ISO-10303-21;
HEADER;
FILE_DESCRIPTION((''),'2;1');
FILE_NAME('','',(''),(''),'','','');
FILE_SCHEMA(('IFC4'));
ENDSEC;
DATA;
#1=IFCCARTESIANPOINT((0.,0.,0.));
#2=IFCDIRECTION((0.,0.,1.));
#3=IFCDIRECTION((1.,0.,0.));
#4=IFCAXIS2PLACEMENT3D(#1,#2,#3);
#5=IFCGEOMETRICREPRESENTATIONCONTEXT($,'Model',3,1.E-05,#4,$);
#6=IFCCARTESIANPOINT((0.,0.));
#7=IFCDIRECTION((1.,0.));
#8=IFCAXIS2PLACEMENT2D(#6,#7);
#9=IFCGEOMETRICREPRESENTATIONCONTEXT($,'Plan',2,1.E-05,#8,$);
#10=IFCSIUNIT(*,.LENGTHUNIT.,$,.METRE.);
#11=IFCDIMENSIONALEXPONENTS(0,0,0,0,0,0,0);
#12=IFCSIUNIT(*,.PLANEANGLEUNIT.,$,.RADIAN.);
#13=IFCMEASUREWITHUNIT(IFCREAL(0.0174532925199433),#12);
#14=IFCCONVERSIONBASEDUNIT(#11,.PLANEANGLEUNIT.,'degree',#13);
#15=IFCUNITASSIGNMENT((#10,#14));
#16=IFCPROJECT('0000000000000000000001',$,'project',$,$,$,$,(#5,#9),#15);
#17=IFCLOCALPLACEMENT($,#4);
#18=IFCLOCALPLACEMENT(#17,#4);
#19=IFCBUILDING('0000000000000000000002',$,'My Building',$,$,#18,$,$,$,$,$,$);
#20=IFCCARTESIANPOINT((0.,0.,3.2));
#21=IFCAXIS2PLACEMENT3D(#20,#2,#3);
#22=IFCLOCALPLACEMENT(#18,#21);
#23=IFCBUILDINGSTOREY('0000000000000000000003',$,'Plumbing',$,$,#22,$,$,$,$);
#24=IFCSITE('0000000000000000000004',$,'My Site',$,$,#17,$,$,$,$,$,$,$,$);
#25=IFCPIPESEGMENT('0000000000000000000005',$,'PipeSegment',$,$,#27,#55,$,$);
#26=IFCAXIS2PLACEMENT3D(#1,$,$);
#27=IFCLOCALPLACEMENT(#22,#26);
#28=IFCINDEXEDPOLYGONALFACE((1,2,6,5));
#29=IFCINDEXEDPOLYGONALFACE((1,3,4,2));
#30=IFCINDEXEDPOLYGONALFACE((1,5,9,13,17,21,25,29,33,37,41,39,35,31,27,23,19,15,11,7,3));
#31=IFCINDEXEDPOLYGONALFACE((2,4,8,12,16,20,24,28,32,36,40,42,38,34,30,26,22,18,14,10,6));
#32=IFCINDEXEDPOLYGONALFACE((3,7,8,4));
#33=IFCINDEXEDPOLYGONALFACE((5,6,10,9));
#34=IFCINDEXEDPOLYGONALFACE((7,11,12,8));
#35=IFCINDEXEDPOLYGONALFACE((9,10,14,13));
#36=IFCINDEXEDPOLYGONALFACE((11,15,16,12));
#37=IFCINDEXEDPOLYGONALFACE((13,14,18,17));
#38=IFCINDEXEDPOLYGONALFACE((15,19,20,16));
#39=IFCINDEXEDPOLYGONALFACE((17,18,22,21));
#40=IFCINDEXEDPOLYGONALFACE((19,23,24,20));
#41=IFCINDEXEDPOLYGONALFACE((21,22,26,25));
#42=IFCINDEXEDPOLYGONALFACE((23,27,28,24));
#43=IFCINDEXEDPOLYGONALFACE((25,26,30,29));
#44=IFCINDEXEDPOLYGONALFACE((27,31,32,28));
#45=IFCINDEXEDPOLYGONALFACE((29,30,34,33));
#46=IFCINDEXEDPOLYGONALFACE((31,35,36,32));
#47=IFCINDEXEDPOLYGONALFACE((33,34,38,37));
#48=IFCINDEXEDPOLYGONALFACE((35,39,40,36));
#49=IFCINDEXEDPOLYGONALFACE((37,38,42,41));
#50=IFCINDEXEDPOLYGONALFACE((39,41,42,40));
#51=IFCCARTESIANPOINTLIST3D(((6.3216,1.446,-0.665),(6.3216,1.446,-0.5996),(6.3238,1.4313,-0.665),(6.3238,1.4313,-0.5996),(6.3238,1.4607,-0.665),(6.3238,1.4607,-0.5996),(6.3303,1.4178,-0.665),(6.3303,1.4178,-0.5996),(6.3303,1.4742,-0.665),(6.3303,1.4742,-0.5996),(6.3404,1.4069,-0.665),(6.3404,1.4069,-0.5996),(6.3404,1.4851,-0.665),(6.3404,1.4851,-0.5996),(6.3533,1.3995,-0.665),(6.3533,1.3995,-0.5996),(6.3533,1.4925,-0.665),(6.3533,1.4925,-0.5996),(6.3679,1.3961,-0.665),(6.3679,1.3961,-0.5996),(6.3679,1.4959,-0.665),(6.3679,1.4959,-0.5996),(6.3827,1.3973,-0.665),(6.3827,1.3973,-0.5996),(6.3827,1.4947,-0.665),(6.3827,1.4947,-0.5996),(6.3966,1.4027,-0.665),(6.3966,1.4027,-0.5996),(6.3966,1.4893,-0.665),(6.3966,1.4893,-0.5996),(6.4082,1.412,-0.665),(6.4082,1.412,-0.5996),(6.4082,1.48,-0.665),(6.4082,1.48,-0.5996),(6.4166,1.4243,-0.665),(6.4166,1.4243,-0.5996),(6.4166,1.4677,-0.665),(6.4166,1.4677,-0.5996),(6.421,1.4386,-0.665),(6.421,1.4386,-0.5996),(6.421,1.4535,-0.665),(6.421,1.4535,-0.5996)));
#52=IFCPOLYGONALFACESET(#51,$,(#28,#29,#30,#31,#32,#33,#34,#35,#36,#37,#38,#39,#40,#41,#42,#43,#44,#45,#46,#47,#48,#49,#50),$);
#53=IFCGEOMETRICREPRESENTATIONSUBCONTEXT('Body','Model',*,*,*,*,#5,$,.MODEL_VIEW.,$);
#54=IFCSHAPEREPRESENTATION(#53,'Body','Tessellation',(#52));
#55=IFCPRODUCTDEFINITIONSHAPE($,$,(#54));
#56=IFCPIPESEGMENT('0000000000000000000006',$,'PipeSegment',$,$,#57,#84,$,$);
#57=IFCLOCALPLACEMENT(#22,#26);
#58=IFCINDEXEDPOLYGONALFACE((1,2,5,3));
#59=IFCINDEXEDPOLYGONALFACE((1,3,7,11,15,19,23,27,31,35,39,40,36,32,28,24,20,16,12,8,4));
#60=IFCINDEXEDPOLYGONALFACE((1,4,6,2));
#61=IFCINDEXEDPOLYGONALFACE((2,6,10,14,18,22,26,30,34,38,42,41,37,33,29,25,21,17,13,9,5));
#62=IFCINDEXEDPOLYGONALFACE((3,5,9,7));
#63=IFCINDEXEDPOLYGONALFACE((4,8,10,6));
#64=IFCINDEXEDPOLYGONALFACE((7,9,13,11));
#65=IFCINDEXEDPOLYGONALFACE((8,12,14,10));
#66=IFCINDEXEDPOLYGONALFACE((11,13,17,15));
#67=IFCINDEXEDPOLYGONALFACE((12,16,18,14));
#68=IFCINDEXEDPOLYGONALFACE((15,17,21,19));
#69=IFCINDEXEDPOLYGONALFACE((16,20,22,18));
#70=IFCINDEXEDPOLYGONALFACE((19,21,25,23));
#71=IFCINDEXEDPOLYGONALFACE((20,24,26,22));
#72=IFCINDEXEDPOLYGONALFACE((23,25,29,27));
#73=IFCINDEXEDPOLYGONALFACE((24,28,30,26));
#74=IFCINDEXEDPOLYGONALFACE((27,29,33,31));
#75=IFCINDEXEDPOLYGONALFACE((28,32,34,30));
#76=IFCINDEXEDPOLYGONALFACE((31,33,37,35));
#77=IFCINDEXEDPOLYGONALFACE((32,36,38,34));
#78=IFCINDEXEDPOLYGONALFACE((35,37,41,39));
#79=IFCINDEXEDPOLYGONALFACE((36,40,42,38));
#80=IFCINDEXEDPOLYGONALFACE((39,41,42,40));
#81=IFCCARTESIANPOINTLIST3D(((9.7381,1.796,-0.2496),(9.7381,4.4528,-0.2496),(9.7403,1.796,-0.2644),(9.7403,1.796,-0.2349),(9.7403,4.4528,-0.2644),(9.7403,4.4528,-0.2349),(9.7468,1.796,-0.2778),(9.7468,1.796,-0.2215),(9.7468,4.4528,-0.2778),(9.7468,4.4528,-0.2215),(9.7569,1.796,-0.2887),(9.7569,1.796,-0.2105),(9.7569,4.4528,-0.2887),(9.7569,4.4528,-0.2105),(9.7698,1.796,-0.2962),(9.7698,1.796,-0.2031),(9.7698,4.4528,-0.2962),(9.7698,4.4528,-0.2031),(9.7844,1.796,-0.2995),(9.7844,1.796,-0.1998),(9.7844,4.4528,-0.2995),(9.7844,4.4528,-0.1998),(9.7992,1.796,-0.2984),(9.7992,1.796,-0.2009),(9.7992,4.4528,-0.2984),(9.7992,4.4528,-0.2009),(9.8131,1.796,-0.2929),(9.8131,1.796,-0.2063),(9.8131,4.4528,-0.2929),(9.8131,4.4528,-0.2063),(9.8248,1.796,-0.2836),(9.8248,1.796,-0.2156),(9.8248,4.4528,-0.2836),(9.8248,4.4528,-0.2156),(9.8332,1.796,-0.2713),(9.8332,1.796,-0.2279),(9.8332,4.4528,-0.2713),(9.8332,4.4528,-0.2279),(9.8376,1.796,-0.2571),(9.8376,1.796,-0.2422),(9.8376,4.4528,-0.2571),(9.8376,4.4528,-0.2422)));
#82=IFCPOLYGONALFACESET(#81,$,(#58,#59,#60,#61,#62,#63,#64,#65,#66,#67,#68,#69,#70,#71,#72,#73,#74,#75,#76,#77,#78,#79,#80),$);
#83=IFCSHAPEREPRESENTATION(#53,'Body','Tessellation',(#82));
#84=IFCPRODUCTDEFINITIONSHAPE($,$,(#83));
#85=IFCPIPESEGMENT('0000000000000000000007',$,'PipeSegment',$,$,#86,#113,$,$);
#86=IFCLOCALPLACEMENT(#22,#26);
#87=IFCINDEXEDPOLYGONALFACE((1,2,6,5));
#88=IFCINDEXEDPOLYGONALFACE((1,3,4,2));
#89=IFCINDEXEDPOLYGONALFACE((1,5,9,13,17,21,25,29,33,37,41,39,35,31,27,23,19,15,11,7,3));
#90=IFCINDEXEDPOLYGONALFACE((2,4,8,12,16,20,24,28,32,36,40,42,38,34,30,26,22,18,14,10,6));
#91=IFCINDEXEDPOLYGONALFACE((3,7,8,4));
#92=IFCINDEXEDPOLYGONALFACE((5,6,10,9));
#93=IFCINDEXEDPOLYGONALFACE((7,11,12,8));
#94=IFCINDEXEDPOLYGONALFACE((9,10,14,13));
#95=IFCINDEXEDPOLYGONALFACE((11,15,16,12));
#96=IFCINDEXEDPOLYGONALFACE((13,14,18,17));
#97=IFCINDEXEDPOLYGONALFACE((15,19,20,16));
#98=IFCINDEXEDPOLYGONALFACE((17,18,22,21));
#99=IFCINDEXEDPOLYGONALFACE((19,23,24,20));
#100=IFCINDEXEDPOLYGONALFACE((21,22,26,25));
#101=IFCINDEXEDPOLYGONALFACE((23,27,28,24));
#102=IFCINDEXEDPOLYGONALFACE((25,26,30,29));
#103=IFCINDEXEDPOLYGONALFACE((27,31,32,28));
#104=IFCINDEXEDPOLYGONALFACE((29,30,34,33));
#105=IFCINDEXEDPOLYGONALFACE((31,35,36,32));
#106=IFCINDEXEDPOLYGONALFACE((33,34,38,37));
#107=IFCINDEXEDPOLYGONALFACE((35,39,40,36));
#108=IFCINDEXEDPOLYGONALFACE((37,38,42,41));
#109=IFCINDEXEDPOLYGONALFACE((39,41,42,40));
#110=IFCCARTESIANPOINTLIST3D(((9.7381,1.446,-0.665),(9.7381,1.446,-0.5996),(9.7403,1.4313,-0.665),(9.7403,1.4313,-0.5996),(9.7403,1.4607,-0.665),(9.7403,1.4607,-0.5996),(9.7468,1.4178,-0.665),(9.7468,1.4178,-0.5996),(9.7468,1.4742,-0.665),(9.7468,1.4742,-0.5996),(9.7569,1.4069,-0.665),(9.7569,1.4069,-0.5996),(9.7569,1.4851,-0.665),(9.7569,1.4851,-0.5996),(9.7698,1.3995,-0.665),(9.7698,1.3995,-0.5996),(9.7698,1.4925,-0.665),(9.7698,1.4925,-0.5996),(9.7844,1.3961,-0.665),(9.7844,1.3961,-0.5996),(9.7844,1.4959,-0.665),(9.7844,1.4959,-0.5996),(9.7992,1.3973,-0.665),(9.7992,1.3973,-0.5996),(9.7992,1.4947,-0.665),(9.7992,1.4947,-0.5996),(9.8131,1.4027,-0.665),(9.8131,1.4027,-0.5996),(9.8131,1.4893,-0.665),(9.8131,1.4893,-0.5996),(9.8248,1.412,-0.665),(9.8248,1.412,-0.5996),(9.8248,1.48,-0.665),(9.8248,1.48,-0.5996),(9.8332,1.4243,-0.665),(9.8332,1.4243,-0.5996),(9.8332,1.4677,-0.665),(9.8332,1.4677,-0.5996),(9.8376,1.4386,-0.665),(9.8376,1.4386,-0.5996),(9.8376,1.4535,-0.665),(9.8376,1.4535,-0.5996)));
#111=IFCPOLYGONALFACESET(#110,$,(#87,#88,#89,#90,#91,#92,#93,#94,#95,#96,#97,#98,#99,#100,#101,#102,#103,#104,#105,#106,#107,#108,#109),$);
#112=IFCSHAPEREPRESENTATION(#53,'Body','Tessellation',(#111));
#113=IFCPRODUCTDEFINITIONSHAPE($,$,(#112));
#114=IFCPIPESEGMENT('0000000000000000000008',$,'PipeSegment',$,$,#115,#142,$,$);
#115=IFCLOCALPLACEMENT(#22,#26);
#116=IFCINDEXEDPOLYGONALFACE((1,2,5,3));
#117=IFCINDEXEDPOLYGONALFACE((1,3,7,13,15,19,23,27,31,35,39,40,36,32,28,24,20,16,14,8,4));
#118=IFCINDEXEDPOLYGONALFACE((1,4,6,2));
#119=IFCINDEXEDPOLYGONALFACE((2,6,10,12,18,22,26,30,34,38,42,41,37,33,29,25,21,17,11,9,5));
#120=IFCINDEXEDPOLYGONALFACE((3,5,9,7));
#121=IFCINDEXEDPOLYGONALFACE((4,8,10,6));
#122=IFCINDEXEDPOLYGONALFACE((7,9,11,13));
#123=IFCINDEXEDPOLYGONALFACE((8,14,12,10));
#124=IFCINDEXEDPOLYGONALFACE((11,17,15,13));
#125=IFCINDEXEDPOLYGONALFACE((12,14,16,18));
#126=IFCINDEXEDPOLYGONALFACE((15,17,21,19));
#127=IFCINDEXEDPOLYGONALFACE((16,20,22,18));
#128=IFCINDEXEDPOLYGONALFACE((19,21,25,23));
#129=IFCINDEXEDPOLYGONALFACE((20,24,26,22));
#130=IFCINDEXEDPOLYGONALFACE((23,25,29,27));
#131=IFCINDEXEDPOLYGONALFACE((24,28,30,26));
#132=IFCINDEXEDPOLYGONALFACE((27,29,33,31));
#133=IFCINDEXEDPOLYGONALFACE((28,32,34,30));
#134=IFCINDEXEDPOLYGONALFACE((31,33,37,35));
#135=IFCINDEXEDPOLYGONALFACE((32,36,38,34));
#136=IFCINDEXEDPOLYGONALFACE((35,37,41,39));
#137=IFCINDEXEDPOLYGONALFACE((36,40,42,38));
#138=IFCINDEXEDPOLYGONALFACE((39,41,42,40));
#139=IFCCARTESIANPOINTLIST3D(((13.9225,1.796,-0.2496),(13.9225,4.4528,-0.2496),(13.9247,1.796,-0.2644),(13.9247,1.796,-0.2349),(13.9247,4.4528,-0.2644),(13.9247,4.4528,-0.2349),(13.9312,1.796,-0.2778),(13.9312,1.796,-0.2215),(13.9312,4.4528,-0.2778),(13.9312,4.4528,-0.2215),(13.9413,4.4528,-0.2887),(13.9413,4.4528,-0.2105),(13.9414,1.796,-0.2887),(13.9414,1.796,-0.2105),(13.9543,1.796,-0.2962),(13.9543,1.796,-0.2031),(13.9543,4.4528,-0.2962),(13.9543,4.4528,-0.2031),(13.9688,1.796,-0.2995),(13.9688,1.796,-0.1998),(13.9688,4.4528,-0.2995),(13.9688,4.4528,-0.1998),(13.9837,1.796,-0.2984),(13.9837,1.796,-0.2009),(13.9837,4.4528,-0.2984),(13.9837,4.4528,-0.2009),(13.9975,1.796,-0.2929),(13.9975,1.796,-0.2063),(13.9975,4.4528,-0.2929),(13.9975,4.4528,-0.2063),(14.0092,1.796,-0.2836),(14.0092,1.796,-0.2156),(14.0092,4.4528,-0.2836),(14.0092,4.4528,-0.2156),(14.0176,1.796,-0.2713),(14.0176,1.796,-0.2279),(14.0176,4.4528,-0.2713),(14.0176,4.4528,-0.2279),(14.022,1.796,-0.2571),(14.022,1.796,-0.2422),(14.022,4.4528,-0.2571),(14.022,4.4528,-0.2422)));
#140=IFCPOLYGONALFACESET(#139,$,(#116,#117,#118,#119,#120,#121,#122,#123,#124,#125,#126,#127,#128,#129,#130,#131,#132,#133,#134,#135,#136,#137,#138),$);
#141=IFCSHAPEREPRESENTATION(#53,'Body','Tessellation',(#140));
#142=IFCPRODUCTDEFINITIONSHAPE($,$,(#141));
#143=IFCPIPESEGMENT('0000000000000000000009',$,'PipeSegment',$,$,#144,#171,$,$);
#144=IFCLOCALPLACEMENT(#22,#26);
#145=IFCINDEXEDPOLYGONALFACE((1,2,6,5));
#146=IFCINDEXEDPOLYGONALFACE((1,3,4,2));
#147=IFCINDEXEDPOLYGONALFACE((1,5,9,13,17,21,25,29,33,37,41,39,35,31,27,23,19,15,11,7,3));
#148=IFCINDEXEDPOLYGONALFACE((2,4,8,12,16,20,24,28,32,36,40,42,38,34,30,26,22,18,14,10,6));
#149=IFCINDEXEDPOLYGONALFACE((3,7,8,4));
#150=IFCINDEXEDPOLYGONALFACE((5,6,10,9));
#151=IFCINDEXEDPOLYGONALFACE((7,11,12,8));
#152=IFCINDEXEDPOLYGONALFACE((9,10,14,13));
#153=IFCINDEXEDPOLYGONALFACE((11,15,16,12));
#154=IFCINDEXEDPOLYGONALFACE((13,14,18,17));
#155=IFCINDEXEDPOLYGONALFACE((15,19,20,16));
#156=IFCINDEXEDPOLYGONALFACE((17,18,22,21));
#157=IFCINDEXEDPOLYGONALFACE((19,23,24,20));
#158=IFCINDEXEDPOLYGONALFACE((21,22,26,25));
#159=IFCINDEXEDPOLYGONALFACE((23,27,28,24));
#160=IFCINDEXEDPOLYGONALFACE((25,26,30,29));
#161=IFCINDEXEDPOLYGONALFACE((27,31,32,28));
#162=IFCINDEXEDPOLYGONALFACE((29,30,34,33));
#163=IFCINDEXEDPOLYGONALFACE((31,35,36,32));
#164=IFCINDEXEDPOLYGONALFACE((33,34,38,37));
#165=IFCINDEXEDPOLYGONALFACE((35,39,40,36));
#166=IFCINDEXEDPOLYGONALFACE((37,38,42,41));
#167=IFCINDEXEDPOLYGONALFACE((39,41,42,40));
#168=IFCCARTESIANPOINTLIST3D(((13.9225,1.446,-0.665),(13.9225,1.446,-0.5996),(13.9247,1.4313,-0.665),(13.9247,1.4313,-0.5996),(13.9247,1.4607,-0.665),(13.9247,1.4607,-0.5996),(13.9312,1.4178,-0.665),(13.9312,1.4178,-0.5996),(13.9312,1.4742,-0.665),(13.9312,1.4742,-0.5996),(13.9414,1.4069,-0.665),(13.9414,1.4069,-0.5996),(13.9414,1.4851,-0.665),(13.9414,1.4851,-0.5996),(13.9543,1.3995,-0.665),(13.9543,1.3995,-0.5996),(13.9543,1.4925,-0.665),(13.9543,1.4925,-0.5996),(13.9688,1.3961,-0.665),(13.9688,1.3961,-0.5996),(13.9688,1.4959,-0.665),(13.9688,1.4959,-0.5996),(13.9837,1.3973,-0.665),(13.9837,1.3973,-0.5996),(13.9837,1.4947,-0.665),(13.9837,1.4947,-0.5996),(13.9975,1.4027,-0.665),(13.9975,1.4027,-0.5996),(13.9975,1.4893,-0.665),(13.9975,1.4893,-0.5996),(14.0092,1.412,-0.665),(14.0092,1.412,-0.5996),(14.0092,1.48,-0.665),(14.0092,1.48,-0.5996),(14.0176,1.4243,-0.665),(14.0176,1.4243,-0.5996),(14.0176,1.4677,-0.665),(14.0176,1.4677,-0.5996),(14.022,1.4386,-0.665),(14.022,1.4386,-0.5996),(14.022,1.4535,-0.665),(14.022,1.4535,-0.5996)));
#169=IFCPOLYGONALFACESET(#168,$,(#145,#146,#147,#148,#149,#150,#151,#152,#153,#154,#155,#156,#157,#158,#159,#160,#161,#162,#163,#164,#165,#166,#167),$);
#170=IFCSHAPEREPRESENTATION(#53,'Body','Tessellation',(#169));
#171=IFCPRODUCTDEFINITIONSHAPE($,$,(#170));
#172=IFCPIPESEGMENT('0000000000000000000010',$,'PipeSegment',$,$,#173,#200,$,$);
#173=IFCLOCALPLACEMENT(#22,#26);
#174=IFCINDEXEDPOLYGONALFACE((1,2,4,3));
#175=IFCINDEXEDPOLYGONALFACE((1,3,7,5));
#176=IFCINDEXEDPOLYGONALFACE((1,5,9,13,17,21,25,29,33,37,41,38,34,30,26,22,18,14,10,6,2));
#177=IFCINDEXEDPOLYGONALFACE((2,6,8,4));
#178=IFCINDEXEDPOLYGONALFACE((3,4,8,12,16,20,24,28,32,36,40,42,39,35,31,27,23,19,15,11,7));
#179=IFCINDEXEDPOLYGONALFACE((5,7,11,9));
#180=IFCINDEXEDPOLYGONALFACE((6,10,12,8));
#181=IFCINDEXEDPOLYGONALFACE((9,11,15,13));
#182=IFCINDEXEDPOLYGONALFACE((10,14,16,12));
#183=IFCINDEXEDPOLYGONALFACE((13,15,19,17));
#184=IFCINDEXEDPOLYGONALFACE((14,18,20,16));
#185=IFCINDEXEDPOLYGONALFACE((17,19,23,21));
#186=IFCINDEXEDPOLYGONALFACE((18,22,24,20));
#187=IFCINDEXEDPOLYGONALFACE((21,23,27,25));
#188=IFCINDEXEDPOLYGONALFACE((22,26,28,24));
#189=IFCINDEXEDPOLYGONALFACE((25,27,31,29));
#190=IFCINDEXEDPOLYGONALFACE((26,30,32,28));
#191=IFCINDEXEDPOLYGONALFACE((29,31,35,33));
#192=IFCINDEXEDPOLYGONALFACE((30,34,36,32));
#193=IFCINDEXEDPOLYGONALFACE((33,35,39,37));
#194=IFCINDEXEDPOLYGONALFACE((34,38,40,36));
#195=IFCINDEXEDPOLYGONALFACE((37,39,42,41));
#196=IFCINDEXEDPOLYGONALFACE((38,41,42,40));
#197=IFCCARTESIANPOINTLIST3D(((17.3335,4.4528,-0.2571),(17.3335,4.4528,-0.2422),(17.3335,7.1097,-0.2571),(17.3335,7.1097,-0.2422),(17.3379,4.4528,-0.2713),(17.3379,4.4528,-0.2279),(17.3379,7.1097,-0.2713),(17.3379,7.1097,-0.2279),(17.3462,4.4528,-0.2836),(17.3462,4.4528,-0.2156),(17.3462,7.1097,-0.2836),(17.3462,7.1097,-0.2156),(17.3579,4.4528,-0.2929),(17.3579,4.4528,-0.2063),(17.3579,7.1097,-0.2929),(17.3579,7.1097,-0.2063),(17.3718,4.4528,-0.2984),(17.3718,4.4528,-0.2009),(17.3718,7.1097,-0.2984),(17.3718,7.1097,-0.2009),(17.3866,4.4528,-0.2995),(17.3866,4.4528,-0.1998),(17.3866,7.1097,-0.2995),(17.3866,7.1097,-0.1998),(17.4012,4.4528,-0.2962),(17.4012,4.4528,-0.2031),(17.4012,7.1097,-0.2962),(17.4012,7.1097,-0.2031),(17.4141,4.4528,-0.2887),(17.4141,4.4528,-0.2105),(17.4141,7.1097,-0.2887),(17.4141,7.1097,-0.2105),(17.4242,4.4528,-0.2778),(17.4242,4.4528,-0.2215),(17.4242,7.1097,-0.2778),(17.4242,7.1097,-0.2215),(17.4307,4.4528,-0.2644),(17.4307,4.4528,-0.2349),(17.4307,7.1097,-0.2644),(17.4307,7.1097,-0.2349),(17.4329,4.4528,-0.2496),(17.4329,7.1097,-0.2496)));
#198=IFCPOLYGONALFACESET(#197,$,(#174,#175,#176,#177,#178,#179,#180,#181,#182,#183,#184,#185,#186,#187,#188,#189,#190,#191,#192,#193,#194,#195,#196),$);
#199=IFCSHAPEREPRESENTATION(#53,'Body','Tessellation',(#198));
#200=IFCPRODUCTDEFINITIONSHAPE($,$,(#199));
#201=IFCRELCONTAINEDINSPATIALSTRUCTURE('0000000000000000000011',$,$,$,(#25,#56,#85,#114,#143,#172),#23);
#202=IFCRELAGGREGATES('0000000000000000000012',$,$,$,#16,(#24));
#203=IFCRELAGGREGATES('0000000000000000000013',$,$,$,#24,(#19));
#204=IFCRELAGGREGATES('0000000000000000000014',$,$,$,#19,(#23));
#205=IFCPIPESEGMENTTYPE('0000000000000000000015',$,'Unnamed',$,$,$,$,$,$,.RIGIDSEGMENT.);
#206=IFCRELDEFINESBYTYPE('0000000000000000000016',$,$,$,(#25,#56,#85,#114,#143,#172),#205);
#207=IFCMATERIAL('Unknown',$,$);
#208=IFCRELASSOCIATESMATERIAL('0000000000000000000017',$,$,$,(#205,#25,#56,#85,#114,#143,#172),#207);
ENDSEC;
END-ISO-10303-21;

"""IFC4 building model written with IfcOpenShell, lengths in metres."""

from ifc_helpers import new_model, entity, si_unit, converted_unit, frame, origin_with_axes, origin_2d_with_axis, place, context, subcontext, project, spatial, circle, extrude, material, material_profile, profile_set, profile_usage, type_object, element, save


model = new_model("IFC4")

# Units and contexts
model_context = context("Model", 3, precision=1e-05, world=origin_with_axes())
plan_context = context("Plan", 2, precision=1e-05, world=origin_2d_with_axis())
body_context = subcontext(model_context, "Body", "Model", "MODEL_VIEW")
ifc_project = project(units=[si_unit("LENGTHUNIT", "METRE"), converted_unit("PLANEANGLEUNIT", "degree", entity("IfcReal", 0.0174532925199433), si_unit("PLANEANGLEUNIT", "RADIAN"), dimensions=[0, 0, 0, 0, 0, 0, 0])], contexts=[model_context, plan_context])

# Site, building, storey
site_placement = place(None, origin_with_axes())
site = spatial("IfcSite", under=ifc_project, at=site_placement, Name="My Site")
building_placement = place(site_placement, origin_with_axes())
building = spatial("IfcBuilding", under=site, at=building_placement, Name="My Building")
storey_placement = place(building_placement, frame((0.0, 0.0, 3.2), z_axis=(0.0, 0.0, 1.0), x_axis=(1.0, 0.0, 0.0)))
storey = spatial("IfcBuildingStorey", under=building, at=storey_placement, Name="Plumbing")

# Pipe segments
ifc_material = material(Name="Unknown")
ifc_material_profile = material_profile(ifc_material, circle(Radius=0.05))
ifc_profile_set = profile_set([ifc_material_profile])
pipe_segment_type = type_object("IfcPipeSegmentType", Name="Unnamed", PredefinedType="RIGIDSEGMENT", material=ifc_profile_set)
ifc_profile_usage_1 = profile_usage(ifc_profile_set, cardinal=5)
pipe_segment_1_placement = place(storey_placement, frame((6.3716, 1.446, -0.5996), z_axis=(0.0, 0.0, -1.0), x_axis=(-1.0, 0.0, 0.0)))
element("IfcPipeSegment", 1, at=pipe_segment_1_placement, inside=storey, type_object=pipe_segment_type, material=ifc_profile_usage_1, Name="PipeSegment", context=body_context, shape_type="SweptSolid", body=[
    extrude(circle(Radius=0.05), origin_with_axes(), (0.0, 0.0, 1.0), 0.0654),
])
ifc_profile_usage_2 = profile_usage(ifc_profile_set, cardinal=5)
pipe_segment_2_placement = place(storey_placement, frame((9.7881, 1.796, -0.2496), z_axis=(0.0, 1.0, 0.0), x_axis=(-1.0, 0.0, 0.0)))
element("IfcPipeSegment", 2, at=pipe_segment_2_placement, inside=storey, type_object=pipe_segment_type, material=ifc_profile_usage_2, Name="PipeSegment", context=body_context, shape_type="SweptSolid", body=[
    extrude(circle(Radius=0.05), origin_with_axes(), (0.0, 0.0, 1.0), 2.6568),
])
ifc_profile_usage_3 = profile_usage(ifc_profile_set, cardinal=5)
pipe_segment_3_placement = place(storey_placement, frame((9.7881, 1.446, -0.5996), z_axis=(0.0, 0.0, -1.0), x_axis=(-1.0, 0.0, 0.0)))
element("IfcPipeSegment", 3, at=pipe_segment_3_placement, inside=storey, type_object=pipe_segment_type, material=ifc_profile_usage_3, Name="PipeSegment", context=body_context, shape_type="SweptSolid", body=[
    extrude(circle(Radius=0.05), origin_with_axes(), (0.0, 0.0, 1.0), 0.0654),
])
ifc_profile_usage_4 = profile_usage(ifc_profile_set, cardinal=5)
pipe_segment_4_placement = place(storey_placement, frame((13.9725, 1.796, -0.2496), z_axis=(0.0, 1.0, 0.0), x_axis=(-1.0, 0.0, 0.0)))
element("IfcPipeSegment", 4, at=pipe_segment_4_placement, inside=storey, type_object=pipe_segment_type, material=ifc_profile_usage_4, Name="PipeSegment", context=body_context, shape_type="SweptSolid", body=[
    extrude(circle(Radius=0.05), origin_with_axes(), (0.0, 0.0, 1.0), 2.6568),
])
ifc_profile_usage_5 = profile_usage(ifc_profile_set, cardinal=5)
pipe_segment_5_placement = place(storey_placement, frame((13.9725, 1.446, -0.5996), z_axis=(0.0, 0.0, -1.0), x_axis=(-1.0, 0.0, 0.0)))
element("IfcPipeSegment", 5, at=pipe_segment_5_placement, inside=storey, type_object=pipe_segment_type, material=ifc_profile_usage_5, Name="PipeSegment", context=body_context, shape_type="SweptSolid", body=[
    extrude(circle(Radius=0.05), origin_with_axes(), (0.0, 0.0, 1.0), 0.0654),
])
ifc_profile_usage_6 = profile_usage(ifc_profile_set, cardinal=5)
pipe_segment_6_placement = place(storey_placement, frame((17.3829, 7.1097, -0.2496), z_axis=(0.0, -1.0, 0.0), x_axis=(1.0, 0.0, 0.0)))
element("IfcPipeSegment", 6, at=pipe_segment_6_placement, inside=storey, type_object=pipe_segment_type, material=ifc_profile_usage_6, Name="PipeSegment", context=body_context, shape_type="SweptSolid", body=[
    extrude(circle(Radius=0.05), origin_with_axes(), (0.0, 0.0, 1.0), 2.6568),
])

save(model, "model.ifc")
